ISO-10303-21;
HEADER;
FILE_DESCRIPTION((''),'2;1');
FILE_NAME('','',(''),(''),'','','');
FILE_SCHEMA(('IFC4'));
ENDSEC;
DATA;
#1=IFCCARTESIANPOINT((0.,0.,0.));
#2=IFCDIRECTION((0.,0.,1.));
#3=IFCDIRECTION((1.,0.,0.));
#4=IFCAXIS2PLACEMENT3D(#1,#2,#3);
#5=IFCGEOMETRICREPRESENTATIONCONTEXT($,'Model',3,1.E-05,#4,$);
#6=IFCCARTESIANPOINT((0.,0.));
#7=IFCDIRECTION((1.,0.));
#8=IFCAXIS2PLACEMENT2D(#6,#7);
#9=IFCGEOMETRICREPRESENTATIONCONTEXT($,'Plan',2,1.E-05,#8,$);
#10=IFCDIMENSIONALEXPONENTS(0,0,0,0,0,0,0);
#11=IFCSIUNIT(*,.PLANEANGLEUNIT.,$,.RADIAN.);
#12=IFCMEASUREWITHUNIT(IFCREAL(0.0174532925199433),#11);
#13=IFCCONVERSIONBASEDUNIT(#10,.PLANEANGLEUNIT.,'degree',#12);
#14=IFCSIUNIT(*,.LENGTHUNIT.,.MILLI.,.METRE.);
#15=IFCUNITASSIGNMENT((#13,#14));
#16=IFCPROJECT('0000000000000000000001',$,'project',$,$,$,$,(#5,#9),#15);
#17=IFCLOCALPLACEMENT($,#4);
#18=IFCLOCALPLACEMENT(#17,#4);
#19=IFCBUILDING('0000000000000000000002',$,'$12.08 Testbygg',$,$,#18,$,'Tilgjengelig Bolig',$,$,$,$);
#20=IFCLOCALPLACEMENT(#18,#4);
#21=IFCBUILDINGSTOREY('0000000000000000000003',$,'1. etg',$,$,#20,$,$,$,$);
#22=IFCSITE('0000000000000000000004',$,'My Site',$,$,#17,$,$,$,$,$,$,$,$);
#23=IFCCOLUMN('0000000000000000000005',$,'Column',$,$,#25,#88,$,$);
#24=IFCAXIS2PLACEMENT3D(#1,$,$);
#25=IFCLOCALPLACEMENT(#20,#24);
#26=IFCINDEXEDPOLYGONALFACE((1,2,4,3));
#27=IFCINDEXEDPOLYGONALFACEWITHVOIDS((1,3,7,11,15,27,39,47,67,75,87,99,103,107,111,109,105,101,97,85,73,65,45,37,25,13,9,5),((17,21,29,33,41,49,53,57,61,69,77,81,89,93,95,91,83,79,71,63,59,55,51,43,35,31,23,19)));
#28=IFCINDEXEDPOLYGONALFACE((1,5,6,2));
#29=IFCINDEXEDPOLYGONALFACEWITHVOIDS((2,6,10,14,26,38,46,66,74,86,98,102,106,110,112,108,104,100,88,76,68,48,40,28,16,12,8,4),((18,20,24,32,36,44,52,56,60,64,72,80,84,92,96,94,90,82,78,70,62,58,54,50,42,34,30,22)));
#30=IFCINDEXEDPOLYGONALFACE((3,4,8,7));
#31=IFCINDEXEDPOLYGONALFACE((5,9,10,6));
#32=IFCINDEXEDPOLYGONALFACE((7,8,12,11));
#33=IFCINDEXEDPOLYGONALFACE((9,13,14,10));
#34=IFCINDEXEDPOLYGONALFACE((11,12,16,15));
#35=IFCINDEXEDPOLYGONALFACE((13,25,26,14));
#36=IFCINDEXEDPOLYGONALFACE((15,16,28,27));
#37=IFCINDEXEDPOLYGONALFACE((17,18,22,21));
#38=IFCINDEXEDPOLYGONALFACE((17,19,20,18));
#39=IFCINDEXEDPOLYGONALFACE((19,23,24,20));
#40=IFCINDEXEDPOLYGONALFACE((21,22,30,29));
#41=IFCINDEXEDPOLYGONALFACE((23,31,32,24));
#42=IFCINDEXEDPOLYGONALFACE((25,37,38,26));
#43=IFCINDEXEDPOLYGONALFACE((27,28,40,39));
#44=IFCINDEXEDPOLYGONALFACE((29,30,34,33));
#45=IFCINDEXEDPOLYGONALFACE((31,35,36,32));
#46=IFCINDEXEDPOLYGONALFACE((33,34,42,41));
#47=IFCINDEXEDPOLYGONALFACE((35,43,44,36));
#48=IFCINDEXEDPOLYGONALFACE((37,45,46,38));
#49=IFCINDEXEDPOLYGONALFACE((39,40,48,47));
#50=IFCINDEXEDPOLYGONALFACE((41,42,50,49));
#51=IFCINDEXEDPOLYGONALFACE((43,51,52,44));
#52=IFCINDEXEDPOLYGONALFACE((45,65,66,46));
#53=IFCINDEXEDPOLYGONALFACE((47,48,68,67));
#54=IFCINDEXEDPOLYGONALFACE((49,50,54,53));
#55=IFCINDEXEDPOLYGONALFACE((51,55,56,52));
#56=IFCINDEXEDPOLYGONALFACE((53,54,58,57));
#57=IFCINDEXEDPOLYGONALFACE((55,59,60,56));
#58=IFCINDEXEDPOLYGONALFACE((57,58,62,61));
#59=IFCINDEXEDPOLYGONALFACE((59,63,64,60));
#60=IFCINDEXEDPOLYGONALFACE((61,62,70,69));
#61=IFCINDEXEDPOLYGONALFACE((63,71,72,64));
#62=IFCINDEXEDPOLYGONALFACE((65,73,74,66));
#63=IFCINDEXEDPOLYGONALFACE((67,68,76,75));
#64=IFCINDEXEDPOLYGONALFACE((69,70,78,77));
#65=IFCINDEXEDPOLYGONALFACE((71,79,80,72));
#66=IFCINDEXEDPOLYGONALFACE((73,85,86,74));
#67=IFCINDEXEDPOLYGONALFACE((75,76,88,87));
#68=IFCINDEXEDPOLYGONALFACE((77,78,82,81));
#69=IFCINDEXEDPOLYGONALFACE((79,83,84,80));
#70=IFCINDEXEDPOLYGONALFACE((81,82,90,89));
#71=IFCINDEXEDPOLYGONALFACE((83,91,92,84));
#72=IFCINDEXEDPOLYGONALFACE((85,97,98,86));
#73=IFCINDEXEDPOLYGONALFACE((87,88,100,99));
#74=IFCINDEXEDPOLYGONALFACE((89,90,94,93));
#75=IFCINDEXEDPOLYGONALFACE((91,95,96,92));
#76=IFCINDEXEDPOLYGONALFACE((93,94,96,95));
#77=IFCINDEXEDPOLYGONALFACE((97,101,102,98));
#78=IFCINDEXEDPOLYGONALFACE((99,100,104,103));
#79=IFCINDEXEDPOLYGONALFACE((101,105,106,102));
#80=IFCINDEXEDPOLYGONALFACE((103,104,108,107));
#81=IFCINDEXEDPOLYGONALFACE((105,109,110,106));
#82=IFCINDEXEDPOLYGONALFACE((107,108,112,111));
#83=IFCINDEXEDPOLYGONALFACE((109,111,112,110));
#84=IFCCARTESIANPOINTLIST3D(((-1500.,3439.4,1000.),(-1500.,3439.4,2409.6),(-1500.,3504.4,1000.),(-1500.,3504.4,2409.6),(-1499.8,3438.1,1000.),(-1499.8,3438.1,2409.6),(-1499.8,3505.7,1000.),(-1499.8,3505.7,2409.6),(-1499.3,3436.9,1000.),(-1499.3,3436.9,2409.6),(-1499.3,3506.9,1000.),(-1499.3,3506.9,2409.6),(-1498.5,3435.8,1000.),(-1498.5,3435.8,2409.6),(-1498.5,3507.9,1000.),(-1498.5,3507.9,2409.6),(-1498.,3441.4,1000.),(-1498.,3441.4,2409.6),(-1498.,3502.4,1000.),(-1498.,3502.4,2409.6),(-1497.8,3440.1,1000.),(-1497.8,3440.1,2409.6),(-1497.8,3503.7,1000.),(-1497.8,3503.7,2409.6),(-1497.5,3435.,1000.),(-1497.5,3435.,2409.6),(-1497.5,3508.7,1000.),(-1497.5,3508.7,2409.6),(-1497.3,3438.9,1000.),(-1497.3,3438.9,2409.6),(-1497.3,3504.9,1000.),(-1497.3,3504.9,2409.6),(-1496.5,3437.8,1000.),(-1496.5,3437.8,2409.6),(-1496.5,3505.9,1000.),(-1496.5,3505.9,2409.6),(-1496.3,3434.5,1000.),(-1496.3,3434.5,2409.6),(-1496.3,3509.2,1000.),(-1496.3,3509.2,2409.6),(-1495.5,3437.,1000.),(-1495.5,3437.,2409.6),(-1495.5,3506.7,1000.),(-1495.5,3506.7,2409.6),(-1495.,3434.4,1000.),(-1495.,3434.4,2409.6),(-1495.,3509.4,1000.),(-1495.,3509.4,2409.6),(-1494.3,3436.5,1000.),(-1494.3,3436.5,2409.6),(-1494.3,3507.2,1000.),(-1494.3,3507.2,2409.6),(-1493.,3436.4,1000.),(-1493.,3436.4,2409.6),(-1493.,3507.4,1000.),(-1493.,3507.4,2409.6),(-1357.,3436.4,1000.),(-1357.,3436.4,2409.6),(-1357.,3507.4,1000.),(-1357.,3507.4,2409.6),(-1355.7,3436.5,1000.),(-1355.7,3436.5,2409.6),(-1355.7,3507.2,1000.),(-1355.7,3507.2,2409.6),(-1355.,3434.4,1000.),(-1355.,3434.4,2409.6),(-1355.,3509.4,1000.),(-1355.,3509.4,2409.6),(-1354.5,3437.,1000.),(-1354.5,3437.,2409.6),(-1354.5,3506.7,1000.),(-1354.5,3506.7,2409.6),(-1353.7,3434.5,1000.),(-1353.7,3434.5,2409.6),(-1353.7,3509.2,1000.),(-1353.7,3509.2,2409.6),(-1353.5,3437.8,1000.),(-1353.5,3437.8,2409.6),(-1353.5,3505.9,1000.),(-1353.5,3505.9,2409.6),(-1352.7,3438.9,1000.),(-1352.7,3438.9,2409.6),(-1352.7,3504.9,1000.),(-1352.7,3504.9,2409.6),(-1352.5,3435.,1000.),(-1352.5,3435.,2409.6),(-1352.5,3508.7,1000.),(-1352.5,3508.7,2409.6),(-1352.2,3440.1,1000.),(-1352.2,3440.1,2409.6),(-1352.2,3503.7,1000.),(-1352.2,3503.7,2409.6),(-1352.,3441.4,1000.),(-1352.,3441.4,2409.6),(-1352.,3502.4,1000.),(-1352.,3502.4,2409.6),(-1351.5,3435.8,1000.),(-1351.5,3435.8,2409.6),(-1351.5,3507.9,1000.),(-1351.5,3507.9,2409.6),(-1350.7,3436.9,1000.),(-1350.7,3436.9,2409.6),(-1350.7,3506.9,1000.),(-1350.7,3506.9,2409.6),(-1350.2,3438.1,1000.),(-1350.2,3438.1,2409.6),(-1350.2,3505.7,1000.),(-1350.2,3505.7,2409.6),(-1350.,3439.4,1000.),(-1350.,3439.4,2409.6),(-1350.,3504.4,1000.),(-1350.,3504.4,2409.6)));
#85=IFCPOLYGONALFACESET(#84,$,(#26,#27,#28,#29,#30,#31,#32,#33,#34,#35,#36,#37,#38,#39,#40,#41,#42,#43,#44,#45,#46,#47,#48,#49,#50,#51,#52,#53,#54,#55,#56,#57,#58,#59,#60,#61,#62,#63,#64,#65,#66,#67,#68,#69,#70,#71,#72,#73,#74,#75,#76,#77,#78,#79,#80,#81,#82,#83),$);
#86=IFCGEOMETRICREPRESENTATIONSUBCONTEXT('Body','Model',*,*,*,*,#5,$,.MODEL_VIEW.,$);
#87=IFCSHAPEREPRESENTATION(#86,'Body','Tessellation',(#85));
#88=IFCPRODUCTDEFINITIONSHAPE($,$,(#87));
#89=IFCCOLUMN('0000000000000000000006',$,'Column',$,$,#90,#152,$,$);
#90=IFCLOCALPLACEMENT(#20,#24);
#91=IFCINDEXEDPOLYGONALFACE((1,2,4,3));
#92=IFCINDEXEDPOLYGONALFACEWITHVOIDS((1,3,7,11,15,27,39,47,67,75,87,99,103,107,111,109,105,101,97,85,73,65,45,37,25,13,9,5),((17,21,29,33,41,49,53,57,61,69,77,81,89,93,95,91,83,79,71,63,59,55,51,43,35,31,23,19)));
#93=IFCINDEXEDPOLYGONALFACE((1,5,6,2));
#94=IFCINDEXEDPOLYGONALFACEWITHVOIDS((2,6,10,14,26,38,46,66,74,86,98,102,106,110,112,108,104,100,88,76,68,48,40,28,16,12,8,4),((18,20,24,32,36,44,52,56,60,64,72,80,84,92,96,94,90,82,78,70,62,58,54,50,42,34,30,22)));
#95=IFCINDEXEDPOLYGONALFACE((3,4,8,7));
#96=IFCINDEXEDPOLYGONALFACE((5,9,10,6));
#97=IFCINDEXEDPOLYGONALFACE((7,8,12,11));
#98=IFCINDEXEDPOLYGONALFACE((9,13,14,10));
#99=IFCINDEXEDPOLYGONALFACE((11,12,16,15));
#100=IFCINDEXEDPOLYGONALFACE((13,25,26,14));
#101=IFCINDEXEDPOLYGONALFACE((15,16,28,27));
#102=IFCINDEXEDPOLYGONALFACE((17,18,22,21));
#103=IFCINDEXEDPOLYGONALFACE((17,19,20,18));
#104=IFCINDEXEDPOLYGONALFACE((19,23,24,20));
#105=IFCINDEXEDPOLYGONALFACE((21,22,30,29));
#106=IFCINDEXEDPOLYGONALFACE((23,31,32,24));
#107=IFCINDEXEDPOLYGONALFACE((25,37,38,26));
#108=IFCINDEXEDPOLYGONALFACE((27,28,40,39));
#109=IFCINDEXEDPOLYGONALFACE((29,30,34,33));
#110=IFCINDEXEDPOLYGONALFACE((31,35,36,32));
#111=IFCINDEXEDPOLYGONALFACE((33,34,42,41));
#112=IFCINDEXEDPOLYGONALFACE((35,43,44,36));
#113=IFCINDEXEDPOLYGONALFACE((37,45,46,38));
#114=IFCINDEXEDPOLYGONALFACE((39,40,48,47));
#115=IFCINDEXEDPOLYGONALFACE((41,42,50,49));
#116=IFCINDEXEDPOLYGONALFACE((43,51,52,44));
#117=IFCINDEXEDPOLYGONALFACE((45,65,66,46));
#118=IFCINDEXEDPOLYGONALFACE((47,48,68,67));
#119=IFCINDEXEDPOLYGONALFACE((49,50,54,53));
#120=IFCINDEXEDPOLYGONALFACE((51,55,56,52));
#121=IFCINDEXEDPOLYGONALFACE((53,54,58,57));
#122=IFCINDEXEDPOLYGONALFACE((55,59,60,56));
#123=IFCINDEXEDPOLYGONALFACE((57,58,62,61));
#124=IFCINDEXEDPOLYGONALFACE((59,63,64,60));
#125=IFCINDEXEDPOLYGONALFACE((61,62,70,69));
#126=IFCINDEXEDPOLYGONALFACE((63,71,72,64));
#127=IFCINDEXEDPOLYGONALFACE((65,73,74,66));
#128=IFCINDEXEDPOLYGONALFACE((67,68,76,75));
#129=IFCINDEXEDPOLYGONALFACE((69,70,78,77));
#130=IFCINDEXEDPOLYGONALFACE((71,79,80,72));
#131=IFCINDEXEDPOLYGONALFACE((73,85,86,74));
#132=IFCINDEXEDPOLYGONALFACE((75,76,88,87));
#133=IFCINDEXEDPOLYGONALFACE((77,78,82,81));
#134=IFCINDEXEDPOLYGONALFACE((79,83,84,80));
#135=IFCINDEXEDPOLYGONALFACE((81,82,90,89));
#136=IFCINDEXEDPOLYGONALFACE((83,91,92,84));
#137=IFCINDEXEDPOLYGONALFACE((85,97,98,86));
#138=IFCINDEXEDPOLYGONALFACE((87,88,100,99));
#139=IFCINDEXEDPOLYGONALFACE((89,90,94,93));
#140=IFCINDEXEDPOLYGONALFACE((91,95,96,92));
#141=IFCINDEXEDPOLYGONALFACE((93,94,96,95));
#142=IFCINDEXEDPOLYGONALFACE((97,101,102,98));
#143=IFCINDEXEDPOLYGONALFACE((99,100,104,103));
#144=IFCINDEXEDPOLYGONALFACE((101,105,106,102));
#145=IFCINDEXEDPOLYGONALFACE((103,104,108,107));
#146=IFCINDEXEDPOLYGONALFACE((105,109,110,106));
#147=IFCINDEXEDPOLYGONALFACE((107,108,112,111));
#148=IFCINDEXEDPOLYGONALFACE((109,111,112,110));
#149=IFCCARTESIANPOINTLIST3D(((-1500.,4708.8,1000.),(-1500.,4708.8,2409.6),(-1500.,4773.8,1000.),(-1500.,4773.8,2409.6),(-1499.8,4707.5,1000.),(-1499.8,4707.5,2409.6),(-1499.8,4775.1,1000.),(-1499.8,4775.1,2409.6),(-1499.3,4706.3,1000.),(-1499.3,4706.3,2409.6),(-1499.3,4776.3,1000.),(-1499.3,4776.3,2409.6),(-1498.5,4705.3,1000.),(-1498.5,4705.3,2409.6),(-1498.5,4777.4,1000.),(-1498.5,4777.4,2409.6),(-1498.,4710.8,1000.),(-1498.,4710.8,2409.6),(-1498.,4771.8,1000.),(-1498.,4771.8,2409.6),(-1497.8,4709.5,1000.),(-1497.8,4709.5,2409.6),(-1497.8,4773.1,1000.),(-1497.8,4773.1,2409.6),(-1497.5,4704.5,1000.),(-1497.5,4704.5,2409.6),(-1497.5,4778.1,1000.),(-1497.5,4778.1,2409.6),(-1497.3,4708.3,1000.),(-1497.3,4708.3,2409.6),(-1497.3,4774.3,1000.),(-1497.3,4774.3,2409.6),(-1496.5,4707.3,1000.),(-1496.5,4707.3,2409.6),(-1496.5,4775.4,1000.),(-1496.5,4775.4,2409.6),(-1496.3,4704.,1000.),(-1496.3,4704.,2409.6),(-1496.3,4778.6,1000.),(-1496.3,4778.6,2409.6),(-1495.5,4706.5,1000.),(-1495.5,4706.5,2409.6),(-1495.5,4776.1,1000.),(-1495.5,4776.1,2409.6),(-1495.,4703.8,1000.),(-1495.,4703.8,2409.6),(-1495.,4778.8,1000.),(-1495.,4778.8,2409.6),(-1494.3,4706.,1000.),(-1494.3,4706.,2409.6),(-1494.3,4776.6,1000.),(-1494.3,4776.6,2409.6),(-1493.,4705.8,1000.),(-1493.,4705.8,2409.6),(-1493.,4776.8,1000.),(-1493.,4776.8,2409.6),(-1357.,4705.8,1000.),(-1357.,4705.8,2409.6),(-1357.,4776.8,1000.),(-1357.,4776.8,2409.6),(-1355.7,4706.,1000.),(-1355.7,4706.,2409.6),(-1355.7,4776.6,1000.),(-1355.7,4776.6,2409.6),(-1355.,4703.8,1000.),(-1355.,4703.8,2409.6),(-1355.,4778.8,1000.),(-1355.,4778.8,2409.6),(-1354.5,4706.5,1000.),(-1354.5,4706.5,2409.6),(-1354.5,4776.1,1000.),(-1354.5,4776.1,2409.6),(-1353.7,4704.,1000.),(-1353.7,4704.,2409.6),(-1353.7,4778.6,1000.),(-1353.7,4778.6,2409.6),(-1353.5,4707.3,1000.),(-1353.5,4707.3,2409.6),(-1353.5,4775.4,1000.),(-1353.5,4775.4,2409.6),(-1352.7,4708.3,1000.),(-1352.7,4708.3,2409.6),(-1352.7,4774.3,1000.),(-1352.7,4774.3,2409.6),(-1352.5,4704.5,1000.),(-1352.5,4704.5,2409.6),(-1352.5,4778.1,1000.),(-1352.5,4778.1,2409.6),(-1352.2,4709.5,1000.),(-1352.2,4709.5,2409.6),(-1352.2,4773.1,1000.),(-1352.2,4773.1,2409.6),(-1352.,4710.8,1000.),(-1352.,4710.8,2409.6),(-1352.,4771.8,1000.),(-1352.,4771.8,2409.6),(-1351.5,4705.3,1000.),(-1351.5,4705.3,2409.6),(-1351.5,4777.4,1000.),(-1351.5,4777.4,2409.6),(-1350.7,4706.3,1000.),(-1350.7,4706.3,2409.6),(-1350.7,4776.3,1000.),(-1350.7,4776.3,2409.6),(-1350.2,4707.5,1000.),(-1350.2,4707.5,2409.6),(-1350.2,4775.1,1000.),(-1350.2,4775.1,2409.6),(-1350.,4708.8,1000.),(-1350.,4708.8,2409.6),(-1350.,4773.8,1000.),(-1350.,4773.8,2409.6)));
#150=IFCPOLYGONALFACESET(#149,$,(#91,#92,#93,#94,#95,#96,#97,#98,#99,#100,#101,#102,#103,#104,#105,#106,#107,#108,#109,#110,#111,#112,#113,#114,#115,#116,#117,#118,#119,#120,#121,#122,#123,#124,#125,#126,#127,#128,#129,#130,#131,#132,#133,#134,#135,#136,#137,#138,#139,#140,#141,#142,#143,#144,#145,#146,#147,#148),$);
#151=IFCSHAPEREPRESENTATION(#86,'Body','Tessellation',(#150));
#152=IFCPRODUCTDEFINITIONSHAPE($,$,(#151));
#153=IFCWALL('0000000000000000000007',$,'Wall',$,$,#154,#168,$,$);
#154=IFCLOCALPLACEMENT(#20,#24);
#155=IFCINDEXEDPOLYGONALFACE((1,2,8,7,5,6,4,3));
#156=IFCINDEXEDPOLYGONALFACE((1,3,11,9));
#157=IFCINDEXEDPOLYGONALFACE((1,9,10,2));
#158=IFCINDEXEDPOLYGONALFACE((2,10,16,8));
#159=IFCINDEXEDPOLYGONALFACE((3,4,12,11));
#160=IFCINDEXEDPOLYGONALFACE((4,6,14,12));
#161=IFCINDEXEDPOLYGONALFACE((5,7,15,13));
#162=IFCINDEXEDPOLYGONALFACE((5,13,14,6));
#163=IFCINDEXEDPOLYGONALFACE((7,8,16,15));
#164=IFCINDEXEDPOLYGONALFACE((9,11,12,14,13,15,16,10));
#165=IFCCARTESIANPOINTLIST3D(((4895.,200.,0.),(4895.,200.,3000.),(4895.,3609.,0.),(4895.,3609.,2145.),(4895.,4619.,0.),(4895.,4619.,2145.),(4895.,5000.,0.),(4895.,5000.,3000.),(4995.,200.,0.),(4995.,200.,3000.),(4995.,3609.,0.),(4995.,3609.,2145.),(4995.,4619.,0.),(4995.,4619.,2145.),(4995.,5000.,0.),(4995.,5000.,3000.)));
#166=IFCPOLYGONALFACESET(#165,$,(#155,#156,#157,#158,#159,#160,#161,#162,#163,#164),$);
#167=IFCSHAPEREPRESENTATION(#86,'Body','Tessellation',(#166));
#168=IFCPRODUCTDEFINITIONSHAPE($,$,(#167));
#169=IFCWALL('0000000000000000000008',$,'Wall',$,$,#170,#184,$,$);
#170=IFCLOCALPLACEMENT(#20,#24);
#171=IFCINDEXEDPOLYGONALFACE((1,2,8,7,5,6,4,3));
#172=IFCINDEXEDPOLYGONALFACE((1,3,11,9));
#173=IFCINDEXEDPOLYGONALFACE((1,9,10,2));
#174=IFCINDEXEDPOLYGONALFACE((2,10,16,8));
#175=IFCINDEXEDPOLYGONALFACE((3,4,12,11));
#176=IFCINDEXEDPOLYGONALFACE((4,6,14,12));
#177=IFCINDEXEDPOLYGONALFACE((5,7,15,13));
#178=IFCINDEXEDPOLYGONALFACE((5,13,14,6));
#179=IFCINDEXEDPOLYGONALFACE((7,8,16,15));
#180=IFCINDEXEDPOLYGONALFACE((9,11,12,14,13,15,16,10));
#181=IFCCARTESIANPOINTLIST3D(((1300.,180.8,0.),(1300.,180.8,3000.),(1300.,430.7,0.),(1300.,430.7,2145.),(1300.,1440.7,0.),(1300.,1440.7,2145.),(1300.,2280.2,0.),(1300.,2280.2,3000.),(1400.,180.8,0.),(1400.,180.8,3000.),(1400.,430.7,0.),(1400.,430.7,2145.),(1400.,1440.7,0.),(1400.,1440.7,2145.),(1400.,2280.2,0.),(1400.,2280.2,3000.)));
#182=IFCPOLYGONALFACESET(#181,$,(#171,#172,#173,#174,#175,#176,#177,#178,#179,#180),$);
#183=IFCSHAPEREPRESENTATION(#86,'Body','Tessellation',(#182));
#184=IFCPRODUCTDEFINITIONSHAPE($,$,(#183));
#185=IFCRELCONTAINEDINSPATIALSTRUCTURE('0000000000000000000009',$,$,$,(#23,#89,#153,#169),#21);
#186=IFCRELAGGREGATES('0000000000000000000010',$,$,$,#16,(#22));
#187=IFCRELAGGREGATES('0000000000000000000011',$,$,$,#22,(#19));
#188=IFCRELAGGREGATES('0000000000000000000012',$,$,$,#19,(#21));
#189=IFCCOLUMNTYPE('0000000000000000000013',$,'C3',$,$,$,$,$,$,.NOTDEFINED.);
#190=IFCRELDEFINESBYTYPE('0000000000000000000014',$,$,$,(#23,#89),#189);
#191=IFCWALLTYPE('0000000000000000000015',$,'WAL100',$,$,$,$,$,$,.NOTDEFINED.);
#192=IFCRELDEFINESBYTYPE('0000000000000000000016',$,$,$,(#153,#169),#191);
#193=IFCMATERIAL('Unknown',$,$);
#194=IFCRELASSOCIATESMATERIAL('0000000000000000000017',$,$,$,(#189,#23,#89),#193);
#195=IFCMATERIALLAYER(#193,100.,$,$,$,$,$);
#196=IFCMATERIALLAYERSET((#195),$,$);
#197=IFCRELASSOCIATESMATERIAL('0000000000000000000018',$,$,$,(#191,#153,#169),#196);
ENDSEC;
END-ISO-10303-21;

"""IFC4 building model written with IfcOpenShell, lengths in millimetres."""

from ifc_helpers import new_model, entity, si_unit, converted_unit, frame, origin_with_axes, origin_2d_with_axis, place, context, subcontext, project, spatial, line, indexed_curve, hollow_rectangle, outline, extrude, source, transform, mapped, material, layer, layer_set, layer_usage, material_profile, profile_set, profile_usage, type_object, element, save


model = new_model("IFC4")

# Units and contexts
model_context = context("Model", 3, precision=1e-05, world=origin_with_axes())
plan_context = context("Plan", 2, precision=1e-05, world=origin_2d_with_axis())
body_context = subcontext(model_context, "Body", "Model", "MODEL_VIEW")
ifc_project = project(units=[converted_unit("PLANEANGLEUNIT", "degree", entity("IfcReal", 0.0174532925199433), si_unit("PLANEANGLEUNIT", "RADIAN"), dimensions=[0, 0, 0, 0, 0, 0, 0]), si_unit("LENGTHUNIT", "METRE", prefix="MILLI")], contexts=[model_context, plan_context])

# Site, building, storey
site_placement = place(None, origin_with_axes())
site = spatial("IfcSite", under=ifc_project, at=site_placement, Name="My Site")
building_placement = place(site_placement, origin_with_axes())
building = spatial("IfcBuilding", under=site, at=building_placement, Name="$12.08 Testbygg", LongName="Tilgjengelig Bolig")
storey_placement = place(building_placement, origin_with_axes())
storey = spatial("IfcBuildingStorey", under=building, at=storey_placement, Name="1. etg")

# Columns
ifc_material = material(Name="Unknown")
ifc_material_profile = material_profile(ifc_material, hollow_rectangle(XDim=75.0, YDim=150.0, WallThickness=2.0, InnerFilletRadius=5.0, OuterFilletRadius=5.0))
ifc_profile_set = profile_set([ifc_material_profile])
ifc_profile_usage_1 = profile_usage(ifc_profile_set, cardinal=5)
column_type = type_object("IfcColumnType", Name="C3", PredefinedType="NOTDEFINED", material=ifc_profile_set)
column_1_placement = place(storey_placement, frame((-1425.0, 3471.9, 1000.0), z_axis=(0.0, 0.0, 1.0), x_axis=(0.0, 1.0, 0.0)))
element("IfcColumn", 1, at=column_1_placement, inside=storey, type_object=column_type, material=ifc_profile_usage_1, Name="Column", context=body_context, shape_type="SweptSolid", body=[
    extrude(hollow_rectangle(XDim=75.0, YDim=150.0, WallThickness=2.0, InnerFilletRadius=5.0, OuterFilletRadius=5.0), origin_with_axes(), (0.0, 0.0, 1.0), 1409.6),
])
ifc_profile_usage_2 = profile_usage(ifc_profile_set, cardinal=5)
column_2_placement = place(storey_placement, frame((-1425.0, 4741.3, 1000.0), z_axis=(0.0, 0.0, 1.0), x_axis=(0.0, 1.0, 0.0)))
element("IfcColumn", 2, at=column_2_placement, inside=storey, type_object=column_type, material=ifc_profile_usage_2, Name="Column", context=body_context, shape_type="SweptSolid", body=[
    extrude(hollow_rectangle(XDim=75.0, YDim=150.0, WallThickness=2.0, InnerFilletRadius=5.0, OuterFilletRadius=5.0), origin_with_axes(), (0.0, 0.0, 1.0), 1409.6),
])

# Walls, openings
ifc_layer_1 = layer(ifc_material, 100.0)
ifc_layer_set_1 = layer_set([ifc_layer_1])
ifc_layer_usage_1 = layer_usage(ifc_layer_set_1, "AXIS2", "POSITIVE", 0.0)
wall_type_1 = type_object("IfcWallType", Name="WAL100", PredefinedType="NOTDEFINED", material=ifc_layer_set_1)
wall_1_placement = place(storey_placement, frame((4995.0, 200.0, 0.0), z_axis=(0.0, 0.0, 1.0), x_axis=(0.0, 1.0, 0.0)))
wall_1 = element("IfcWall", 3, at=wall_1_placement, inside=storey, type_object=wall_type_1, material=ifc_layer_usage_1, Name="Wall", context=body_context, shape_type="SweptSolid", body=[
    extrude(outline(indexed_curve([(0.0, 0.0), (0.0, 100.0), (4800.0, 100.0), (4800.0, 0.0), (0.0, 0.0)], self_intersect=False)), origin_with_axes(), (0.0, 0.0, 1.0), 3000.0),
])
shared_shape_1 = source(origin_with_axes(), body_context, "Body", "SweptSolid", [
    extrude(outline(indexed_curve([(0.0, 0.0), (1010.0, 0.0), (1010.0, 2145.0), (0.0, 2145.0)], segments=[line(1, 2), line(2, 3), line(3, 4), line(4, 1)])), frame((0.0, -100.0, 0.0), z_axis=(0.0, -1.0, 0.0), x_axis=(1.0, 0.0, 0.0)), (0.0, 0.0, -1.0), 400.0),
])
opening_1_placement = place(wall_1_placement, frame((3409.0, 0.0, 0.0), z_axis=(0.0, 0.0, 1.0), x_axis=(1.0, 0.0, 0.0)))
element("IfcOpeningElement", 4, at=opening_1_placement, cuts=wall_1, PredefinedType="OPENING", context=body_context, shape_type="MappedRepresentation", body=[
    mapped(shared_shape_1, transform((0.0, 0.0, 0.0), x_axis=(1.0, 0.0, 0.0), y_axis=(0.0, 1.0, 0.0), z_axis=(0.0, 0.0, 1.0), scale=1.0)),
])
ifc_layer_usage_2 = layer_usage(ifc_layer_set_1, "AXIS2", "POSITIVE", 0.0)
wall_2_placement = place(storey_placement, frame((1400.0, 180.8, 0.0), z_axis=(0.0, 0.0, 1.0), x_axis=(0.000001, 1.0, 0.0)))
wall_2 = element("IfcWall", 5, at=wall_2_placement, inside=storey, type_object=wall_type_1, material=ifc_layer_usage_2, Name="Wall", context=body_context, shape_type="SweptSolid", body=[
    extrude(outline(indexed_curve([(0.0, 0.0), (0.0, 100.0), (2099.4, 100.0), (2099.4, 0.0), (0.0, 0.0)], self_intersect=False)), origin_with_axes(), (0.0, 0.0, 1.0), 3000.0),
])
opening_2_placement = place(wall_2_placement, frame((249.9, 0.0, 0.0), z_axis=(0.0, 0.0, 1.0), x_axis=(1.0, 0.0, 0.0)))
element("IfcOpeningElement", 6, at=opening_2_placement, cuts=wall_2, PredefinedType="OPENING", context=body_context, shape_type="MappedRepresentation", body=[
    mapped(shared_shape_1, transform((0.0, 0.0, 0.0), x_axis=(1.0, 0.0, 0.0), y_axis=(0.0, 1.0, 0.0), z_axis=(0.0, 0.0, 1.0), scale=1.0)),
])

save(model, "model.ifc")
